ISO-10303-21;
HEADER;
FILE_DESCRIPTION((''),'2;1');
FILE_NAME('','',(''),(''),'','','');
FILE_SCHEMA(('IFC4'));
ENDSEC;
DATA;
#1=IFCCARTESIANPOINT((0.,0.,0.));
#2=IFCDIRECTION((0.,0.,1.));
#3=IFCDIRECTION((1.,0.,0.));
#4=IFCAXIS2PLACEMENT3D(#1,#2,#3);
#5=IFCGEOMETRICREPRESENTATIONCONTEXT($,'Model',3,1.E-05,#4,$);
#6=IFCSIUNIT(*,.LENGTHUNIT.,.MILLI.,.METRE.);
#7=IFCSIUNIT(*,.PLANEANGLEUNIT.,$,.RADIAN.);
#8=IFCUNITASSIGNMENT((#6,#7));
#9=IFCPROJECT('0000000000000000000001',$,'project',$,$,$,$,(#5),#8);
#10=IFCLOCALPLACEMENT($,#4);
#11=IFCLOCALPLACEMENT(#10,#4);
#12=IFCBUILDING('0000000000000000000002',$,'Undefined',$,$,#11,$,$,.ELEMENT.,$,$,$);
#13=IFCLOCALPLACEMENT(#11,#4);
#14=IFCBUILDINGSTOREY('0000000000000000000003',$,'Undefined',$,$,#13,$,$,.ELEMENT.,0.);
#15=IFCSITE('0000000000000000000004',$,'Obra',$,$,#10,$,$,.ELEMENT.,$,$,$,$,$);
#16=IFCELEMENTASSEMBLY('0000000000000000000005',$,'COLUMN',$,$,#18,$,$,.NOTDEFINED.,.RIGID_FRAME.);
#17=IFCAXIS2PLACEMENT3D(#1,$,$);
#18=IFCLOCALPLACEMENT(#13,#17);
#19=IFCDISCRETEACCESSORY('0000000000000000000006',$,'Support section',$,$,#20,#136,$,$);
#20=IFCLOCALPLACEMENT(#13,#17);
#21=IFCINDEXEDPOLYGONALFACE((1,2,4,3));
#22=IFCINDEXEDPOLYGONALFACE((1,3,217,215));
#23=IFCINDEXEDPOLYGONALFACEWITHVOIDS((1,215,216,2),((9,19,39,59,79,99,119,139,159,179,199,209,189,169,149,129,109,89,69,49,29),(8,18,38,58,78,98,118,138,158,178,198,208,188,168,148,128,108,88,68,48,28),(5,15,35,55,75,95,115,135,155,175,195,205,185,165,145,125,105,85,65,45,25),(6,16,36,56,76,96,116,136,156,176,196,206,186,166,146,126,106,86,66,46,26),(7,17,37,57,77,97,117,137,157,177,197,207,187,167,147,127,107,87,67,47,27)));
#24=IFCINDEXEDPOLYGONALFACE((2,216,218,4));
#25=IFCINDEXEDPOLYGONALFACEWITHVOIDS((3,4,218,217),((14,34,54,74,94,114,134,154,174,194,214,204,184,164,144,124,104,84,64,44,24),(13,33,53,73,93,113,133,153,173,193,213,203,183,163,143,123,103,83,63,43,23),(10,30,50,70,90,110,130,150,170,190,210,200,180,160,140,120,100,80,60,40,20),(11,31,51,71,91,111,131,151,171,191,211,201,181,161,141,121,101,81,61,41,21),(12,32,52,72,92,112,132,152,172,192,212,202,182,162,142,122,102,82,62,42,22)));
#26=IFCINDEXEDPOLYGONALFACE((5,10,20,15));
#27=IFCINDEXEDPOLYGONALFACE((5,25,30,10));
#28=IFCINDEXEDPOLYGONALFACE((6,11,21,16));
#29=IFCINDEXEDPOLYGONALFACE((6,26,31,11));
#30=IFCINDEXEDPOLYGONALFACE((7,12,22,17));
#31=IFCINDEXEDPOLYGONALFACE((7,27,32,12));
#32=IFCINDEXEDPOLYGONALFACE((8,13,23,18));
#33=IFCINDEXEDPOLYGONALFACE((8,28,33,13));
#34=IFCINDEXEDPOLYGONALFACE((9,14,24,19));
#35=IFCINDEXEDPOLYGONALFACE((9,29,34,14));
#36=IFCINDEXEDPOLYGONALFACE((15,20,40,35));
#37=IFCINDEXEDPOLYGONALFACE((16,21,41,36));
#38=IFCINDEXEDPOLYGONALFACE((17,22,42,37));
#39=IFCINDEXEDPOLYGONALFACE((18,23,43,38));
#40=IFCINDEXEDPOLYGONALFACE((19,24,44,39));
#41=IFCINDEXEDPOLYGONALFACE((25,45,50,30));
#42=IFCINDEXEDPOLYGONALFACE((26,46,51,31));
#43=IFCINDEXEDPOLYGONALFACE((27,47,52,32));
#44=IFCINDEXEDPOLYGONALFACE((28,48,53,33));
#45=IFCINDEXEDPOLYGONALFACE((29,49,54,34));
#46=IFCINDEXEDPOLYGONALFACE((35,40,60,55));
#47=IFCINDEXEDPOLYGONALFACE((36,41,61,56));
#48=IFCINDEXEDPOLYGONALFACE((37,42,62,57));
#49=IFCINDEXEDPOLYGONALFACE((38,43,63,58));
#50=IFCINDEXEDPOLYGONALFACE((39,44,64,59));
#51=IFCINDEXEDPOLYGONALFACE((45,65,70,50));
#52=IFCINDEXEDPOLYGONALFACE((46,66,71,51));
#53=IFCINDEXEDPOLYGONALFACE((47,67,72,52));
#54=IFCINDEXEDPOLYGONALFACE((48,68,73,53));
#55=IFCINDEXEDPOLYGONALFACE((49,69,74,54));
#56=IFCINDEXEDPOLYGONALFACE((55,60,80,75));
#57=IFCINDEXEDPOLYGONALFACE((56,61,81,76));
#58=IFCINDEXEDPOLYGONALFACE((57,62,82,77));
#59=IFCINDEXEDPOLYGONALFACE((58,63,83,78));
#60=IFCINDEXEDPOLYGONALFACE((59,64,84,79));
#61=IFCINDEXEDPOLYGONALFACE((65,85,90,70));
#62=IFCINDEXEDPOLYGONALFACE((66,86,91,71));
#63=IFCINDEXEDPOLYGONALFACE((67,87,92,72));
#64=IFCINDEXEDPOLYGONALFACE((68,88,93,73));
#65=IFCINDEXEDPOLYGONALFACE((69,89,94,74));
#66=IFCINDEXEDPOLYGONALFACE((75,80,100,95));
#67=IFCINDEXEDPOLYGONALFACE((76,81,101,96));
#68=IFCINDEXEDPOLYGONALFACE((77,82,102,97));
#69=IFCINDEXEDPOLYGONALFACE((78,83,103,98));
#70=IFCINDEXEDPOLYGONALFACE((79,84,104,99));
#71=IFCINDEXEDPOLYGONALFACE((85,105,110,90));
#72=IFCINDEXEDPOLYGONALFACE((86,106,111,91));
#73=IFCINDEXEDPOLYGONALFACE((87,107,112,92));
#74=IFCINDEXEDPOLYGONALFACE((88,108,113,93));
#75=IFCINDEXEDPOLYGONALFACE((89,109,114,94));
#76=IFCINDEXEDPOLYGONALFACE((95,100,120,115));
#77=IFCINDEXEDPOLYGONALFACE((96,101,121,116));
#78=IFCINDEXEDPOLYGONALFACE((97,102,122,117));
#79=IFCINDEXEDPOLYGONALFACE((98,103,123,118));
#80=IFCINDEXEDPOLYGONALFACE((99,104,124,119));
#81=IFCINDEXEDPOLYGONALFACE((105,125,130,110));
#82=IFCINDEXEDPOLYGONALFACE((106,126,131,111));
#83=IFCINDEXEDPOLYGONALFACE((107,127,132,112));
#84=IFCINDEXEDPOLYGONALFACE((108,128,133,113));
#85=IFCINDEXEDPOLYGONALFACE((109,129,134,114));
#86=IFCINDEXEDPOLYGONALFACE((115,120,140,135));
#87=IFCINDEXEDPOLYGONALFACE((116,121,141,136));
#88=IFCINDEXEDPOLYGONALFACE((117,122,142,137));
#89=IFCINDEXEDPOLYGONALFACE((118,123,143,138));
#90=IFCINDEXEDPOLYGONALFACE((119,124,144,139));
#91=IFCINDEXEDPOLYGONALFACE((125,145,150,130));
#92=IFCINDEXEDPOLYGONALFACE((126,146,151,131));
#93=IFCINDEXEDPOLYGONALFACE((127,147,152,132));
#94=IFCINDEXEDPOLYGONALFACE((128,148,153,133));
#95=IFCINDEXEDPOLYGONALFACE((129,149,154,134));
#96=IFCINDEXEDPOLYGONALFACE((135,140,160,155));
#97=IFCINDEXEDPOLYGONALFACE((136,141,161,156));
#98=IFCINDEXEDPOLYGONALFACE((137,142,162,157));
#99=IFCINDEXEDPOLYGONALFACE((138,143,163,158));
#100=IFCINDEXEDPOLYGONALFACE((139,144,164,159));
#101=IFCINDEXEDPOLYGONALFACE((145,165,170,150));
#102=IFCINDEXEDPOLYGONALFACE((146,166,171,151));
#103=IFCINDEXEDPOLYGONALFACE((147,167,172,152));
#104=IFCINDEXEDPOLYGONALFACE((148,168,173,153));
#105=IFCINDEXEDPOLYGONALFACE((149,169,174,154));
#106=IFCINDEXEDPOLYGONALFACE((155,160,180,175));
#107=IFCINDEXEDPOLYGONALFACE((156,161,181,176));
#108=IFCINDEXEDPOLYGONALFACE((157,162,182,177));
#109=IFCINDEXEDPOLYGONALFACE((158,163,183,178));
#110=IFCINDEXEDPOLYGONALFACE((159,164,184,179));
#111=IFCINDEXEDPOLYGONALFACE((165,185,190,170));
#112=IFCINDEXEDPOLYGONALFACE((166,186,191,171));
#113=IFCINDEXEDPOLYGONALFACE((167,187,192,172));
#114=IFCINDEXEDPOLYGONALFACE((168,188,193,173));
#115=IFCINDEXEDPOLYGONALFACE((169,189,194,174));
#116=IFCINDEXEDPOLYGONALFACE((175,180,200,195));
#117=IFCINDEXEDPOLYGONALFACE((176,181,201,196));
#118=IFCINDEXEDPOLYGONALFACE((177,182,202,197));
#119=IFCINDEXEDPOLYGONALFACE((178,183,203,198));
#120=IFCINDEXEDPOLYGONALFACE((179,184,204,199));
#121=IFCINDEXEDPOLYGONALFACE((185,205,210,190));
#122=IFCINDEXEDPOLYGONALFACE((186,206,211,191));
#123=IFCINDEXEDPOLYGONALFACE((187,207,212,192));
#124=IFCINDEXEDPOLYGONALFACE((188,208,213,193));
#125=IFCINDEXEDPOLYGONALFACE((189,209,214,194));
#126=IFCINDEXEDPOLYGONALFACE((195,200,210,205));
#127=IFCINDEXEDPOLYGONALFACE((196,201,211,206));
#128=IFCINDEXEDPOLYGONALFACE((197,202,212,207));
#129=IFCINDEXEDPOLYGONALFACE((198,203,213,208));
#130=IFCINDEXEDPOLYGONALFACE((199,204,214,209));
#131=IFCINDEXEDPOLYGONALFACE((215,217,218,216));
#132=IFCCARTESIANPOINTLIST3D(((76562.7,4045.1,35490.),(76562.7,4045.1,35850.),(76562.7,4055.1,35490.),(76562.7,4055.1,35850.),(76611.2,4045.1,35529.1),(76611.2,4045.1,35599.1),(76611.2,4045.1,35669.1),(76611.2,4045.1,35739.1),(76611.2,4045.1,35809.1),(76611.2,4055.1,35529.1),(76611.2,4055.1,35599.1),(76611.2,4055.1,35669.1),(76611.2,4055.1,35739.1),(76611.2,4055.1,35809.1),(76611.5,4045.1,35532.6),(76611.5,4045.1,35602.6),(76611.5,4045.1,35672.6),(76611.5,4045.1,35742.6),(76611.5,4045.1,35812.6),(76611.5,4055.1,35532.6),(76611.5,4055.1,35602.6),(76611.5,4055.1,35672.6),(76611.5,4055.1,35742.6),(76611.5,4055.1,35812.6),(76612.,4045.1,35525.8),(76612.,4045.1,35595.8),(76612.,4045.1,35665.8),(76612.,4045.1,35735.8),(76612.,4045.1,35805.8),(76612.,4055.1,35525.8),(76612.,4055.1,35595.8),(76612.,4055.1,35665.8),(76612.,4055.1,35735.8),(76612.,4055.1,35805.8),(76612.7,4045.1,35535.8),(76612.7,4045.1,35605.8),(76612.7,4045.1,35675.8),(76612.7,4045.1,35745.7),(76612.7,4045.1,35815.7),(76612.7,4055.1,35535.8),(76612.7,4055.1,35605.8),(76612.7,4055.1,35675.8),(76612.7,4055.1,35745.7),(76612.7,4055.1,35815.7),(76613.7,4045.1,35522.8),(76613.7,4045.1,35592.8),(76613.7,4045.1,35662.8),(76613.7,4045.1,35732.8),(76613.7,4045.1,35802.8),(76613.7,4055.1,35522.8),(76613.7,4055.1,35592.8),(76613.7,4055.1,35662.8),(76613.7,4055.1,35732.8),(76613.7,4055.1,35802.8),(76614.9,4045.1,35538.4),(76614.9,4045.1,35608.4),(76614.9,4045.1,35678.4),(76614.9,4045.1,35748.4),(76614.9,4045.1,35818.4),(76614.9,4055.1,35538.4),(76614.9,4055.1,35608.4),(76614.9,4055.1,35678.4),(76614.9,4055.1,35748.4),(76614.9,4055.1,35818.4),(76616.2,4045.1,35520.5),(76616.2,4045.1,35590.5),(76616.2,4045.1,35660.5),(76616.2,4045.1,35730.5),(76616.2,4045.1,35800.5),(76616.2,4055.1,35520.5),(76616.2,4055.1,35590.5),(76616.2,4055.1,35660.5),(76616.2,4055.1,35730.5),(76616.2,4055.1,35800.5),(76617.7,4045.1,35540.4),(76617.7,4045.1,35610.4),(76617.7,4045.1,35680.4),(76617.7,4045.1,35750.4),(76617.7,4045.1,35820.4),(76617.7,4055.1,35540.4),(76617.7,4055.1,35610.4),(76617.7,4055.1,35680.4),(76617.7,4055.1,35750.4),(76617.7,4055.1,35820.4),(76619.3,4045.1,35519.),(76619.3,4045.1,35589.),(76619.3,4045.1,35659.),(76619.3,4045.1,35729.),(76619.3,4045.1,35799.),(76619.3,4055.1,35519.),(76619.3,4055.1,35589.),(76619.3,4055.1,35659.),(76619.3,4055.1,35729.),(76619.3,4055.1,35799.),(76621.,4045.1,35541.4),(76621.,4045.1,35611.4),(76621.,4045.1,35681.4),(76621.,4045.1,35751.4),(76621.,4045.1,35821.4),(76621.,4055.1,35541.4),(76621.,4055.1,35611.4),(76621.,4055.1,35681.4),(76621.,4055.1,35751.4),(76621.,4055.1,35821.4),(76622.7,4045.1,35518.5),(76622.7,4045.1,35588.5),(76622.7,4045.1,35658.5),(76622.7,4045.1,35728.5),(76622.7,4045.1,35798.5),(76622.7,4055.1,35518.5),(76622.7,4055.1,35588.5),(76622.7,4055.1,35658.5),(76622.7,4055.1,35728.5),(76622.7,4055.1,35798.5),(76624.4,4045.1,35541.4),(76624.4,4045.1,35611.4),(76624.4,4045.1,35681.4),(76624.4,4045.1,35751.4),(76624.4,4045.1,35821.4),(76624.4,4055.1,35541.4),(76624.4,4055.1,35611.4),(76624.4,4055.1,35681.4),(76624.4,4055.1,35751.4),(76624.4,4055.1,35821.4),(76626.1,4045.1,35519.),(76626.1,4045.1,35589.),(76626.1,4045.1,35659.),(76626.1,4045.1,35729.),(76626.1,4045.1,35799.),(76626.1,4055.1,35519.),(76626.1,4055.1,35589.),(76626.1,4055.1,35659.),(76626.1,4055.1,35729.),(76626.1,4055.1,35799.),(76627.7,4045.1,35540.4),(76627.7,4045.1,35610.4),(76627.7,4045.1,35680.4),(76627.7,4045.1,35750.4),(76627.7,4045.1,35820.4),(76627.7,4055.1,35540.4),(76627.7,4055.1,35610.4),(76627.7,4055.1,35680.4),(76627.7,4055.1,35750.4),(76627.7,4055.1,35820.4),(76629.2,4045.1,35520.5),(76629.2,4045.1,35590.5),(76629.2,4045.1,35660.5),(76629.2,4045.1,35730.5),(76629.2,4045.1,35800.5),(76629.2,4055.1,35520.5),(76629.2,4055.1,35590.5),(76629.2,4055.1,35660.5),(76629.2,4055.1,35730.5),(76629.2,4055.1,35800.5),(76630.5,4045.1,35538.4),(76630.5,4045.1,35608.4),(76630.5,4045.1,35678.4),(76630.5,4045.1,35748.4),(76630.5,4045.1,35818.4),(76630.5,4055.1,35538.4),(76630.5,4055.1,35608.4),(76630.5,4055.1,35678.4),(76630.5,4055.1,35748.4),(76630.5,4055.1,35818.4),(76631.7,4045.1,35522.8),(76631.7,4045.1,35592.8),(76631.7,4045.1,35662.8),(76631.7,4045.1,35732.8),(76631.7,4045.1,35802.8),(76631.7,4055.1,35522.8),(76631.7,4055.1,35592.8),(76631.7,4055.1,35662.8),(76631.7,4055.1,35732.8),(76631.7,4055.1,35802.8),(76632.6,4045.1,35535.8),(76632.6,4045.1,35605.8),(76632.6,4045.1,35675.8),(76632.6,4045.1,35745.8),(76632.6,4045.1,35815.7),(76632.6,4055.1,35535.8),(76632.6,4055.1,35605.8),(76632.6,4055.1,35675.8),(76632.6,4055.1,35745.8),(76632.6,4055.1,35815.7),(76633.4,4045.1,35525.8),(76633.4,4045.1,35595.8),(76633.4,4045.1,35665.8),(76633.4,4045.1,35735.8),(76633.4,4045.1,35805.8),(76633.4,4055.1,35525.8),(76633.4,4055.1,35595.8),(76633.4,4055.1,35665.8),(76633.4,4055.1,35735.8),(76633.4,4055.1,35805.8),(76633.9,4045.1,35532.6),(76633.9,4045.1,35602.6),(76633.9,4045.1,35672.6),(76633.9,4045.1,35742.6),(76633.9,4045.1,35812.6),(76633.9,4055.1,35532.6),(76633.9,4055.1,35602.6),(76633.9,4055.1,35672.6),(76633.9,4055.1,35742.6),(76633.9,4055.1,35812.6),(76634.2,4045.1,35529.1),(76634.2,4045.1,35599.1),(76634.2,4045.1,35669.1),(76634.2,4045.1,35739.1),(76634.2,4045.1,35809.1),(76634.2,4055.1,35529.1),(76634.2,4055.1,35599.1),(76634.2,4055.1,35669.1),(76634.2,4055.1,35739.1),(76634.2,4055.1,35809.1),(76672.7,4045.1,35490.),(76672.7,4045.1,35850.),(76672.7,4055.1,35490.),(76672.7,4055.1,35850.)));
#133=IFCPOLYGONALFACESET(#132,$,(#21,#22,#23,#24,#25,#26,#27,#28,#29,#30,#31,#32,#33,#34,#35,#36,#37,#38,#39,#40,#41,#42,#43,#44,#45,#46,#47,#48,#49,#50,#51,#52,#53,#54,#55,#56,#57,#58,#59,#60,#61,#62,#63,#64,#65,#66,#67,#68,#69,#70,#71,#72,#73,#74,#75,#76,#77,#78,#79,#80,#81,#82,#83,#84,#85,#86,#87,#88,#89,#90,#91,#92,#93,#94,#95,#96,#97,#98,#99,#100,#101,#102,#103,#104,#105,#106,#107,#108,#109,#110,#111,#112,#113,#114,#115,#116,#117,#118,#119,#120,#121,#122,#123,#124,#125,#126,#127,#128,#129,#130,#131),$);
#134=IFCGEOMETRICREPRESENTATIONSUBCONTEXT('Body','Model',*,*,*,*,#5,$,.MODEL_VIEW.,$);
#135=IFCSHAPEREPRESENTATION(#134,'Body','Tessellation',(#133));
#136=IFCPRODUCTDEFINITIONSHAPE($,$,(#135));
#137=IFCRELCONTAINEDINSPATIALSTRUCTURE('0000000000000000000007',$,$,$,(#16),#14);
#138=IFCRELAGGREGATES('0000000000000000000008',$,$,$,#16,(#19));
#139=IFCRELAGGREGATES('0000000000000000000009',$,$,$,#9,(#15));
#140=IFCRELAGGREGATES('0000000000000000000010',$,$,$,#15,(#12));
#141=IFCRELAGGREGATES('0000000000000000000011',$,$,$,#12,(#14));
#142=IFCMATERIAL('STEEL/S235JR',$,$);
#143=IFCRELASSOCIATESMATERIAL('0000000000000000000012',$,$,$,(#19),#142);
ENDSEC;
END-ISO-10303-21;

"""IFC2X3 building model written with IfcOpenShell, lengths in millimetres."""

from ifc_helpers import new_model, si_unit, frame, origin_with_axes, origin_2d_with_axis, place, context, subcontext, project, spatial, rectangle, circle, extrude, source, transform, mapped, material, element, aggregate, save


model = new_model("IFC2X3")

# Units and contexts
model_context = context("Model", 3, precision=1e-05, world=origin_with_axes())
body_context = subcontext(model_context, "Body", "Model", "MODEL_VIEW")
ifc_project = project(units=[si_unit("LENGTHUNIT", "METRE", prefix="MILLI"), si_unit("PLANEANGLEUNIT", "RADIAN")], contexts=[model_context])

# Site, building, storey
site_placement = place(None, origin_with_axes())
site = spatial("IfcSite", under=ifc_project, at=site_placement, Name="Obra", CompositionType="ELEMENT")
building_placement = place(site_placement, origin_with_axes())
building = spatial("IfcBuilding", under=site, at=building_placement, Name="Undefined", CompositionType="ELEMENT")
storey_placement = place(building_placement, origin_with_axes())
storey = spatial("IfcBuildingStorey", under=building, at=storey_placement, Name="Undefined", CompositionType="ELEMENT", Elevation=0.0)

# Shared definitions
ifc_material_1 = material(Name="STEEL/S235JR")

# Element assembly, discrete accessory, opening
assembly_1_placement = place(storey_placement, origin_with_axes())
assembly_1 = element("IfcElementAssembly", 1, at=assembly_1_placement, inside=storey, Name="COLUMN", AssemblyPlace="NOTDEFINED", PredefinedType="RIGID_FRAME")
discrete_accessory_1_placement = place(assembly_1_placement, frame((76617.7, 4050.1, 35490.0), z_axis=(0.0, 0.0, 1.0), x_axis=(-1.0, 0.0, 0.0)))
discrete_accessory_1 = element("IfcDiscreteAccessory", 2, at=discrete_accessory_1_placement, material=ifc_material_1, Name="Support section", context=body_context, shape_type="SweptSolid", body=[
    extrude(rectangle(XDim=10.0, YDim=110.0, at=origin_2d_with_axis()), frame((0.0, 0.0, 360.0), z_axis=(0.0, 0.0, -1.0), x_axis=(0.0, 1.0, 0.0)), (0.0, 0.0, 1.0), 360.0),
])
shared_shape_1 = source(origin_with_axes(), body_context, "Body", "SweptSolid", [
    extrude(circle(Radius=11.5, at=origin_2d_with_axis()), frame((0.0, -14.4, 0.0), z_axis=(0.0, 1.0, 0.0), x_axis=(1.0, 0.0, 0.0)), (0.0, 0.0, 1.0), 10.2),
])
opening_1_placement = place(assembly_1_placement, frame((76572.7, 4059.4, 35870.0), z_axis=(1.0, 0.0, 0.0), x_axis=(0.0, 0.0, -1.0)))
element("IfcOpeningElement", 3, at=opening_1_placement, cuts=discrete_accessory_1, ObjectType="Opening", context=body_context, shape_type="MappedRepresentation", body=[
    mapped(shared_shape_1, transform((60.0, 0.0, 50.0))),
    mapped(shared_shape_1, transform((130.0, 0.0, 50.0))),
    mapped(shared_shape_1, transform((200.0, 0.0, 50.0))),
    mapped(shared_shape_1, transform((270.0, 0.0, 50.0))),
    mapped(shared_shape_1, transform((340.0, 0.0, 50.0))),
])

aggregate(assembly_1, [discrete_accessory_1])

save(model, "model.ifc")
